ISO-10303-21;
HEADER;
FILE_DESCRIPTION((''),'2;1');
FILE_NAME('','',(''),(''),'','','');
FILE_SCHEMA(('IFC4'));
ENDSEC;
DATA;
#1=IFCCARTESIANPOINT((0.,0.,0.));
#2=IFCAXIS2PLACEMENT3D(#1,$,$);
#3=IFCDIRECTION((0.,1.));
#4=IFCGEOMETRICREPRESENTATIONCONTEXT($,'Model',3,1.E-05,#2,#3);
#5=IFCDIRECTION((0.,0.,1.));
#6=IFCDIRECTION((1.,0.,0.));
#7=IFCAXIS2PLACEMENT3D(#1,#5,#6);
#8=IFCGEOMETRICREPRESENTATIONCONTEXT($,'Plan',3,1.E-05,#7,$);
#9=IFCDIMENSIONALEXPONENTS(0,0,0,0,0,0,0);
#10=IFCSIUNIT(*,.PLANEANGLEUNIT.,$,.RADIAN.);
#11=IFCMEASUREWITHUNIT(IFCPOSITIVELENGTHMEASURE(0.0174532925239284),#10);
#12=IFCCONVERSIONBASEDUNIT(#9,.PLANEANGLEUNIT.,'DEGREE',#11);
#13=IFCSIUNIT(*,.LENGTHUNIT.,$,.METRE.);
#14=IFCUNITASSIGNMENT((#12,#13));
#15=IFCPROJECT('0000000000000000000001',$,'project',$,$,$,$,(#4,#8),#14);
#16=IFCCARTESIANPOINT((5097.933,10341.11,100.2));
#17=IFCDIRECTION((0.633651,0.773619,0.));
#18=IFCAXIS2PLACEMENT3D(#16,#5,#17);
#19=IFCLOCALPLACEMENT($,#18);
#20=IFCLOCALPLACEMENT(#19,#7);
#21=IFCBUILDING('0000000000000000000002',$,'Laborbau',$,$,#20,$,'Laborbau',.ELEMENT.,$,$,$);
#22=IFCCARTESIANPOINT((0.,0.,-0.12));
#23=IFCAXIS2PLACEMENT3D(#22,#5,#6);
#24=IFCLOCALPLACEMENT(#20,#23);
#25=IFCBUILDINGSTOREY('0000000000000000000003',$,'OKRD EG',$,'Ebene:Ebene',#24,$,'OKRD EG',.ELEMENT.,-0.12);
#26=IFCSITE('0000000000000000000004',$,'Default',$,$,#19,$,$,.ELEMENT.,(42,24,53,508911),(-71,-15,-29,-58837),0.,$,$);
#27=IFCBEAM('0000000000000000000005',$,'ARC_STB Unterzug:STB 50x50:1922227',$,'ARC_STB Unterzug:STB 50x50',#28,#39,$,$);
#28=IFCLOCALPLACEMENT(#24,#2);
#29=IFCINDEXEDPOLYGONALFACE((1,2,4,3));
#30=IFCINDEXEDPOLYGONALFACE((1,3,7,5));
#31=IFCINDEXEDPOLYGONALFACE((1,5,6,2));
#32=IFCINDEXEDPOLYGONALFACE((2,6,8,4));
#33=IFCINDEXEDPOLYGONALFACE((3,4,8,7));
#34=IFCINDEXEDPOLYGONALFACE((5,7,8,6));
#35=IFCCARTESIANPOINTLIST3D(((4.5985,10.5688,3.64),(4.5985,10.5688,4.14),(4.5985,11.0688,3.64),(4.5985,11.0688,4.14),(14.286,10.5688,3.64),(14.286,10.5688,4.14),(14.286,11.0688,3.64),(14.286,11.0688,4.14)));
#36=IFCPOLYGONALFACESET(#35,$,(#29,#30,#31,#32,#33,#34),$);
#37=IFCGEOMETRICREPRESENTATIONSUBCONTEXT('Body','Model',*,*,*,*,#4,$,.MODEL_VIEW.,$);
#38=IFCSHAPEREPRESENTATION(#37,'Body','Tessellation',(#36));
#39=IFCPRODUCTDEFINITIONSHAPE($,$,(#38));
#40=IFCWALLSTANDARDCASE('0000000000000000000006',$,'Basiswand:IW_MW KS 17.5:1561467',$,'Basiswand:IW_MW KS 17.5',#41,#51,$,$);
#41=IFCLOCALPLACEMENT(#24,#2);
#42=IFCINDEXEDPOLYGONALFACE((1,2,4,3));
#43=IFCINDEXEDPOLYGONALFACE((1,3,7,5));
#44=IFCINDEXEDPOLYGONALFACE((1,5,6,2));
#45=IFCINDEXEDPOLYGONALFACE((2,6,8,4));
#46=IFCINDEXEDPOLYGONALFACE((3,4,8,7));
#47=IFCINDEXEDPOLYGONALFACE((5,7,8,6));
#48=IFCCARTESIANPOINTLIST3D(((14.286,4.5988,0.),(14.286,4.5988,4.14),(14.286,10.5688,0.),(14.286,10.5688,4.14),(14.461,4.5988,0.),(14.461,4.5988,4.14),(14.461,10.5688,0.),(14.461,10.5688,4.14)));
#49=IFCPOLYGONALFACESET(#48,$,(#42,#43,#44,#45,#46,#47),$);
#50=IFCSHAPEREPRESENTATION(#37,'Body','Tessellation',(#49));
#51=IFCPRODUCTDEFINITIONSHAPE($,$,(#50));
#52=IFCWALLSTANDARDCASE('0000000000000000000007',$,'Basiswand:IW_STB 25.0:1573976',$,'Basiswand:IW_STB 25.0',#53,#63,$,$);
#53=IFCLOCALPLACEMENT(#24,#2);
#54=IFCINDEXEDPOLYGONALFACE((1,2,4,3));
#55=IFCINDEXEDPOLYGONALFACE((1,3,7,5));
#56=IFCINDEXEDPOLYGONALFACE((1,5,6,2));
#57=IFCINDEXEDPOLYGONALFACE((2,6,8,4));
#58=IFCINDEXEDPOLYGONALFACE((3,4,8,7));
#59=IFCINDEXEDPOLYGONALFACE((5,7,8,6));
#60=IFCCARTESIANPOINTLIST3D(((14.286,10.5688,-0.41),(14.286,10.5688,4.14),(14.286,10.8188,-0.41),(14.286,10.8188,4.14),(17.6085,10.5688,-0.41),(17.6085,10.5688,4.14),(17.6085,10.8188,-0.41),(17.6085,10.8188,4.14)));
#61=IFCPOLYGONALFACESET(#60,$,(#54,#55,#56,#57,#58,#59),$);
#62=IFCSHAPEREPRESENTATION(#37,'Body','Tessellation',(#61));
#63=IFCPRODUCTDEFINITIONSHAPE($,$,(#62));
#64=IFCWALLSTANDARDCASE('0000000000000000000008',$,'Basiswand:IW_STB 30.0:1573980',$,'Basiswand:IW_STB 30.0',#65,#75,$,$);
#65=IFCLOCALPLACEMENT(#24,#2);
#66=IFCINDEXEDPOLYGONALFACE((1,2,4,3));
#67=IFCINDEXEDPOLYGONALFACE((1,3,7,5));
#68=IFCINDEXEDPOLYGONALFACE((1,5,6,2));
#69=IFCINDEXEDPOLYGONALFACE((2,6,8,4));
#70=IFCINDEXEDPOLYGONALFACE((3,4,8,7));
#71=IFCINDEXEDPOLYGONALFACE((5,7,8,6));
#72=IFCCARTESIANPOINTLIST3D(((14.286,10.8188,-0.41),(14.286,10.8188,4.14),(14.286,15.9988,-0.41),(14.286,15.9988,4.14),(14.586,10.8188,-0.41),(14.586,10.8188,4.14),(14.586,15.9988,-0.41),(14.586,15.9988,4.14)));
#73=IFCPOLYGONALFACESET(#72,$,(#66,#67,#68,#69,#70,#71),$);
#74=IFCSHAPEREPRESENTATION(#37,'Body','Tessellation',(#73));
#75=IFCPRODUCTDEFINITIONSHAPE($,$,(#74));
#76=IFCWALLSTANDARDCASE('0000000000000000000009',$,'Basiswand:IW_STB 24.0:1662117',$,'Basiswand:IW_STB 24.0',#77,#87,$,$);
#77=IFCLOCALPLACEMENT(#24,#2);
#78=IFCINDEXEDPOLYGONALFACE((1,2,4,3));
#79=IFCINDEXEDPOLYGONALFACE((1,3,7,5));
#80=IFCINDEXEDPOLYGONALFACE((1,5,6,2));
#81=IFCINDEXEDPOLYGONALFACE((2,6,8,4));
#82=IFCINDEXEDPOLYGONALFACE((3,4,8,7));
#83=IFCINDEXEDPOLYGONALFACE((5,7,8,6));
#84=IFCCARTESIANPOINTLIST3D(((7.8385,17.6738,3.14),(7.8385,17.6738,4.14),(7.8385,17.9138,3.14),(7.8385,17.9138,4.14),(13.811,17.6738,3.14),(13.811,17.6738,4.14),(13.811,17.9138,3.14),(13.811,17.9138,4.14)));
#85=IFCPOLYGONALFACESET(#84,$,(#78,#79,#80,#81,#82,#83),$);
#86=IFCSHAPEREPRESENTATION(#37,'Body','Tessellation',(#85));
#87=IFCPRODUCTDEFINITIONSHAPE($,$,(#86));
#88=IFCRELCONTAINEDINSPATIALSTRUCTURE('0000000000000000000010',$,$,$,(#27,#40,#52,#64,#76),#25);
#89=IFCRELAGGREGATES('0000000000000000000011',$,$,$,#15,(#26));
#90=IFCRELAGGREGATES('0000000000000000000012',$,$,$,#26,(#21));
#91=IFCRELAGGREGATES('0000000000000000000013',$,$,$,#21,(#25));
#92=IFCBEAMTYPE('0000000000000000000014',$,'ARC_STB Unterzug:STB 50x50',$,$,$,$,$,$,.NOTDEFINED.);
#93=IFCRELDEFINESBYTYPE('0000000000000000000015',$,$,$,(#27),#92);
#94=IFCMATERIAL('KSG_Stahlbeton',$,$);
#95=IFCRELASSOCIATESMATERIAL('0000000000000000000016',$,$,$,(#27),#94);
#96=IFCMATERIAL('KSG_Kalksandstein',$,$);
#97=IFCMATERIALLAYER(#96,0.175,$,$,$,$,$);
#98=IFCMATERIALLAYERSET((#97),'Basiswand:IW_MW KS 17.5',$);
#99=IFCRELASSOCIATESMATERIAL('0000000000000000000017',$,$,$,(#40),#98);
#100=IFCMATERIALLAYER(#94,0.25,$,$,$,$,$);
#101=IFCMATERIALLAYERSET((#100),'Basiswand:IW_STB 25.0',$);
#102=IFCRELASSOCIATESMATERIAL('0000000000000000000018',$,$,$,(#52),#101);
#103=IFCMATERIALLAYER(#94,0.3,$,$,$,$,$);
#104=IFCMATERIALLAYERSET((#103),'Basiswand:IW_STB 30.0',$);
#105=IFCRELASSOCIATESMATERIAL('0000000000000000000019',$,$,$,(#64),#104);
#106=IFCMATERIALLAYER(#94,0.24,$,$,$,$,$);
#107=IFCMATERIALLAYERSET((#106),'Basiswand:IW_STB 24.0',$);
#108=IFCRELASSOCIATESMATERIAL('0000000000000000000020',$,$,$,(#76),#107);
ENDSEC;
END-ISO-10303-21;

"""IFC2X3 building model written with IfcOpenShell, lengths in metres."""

from ifc_helpers import new_model, entity, si_unit, converted_unit, direction, frame, frame_2d, origin, origin_with_axes, place, context, subcontext, project, spatial, rectangle, extrude, material, layer, layer_set, layer_usage, type_object, element, save


model = new_model("IFC2X3")

# Units and contexts
model_context = context("Model", 3, precision=1e-05, world=origin(), true_north=direction((0.0, 1.0)))
plan_context = context("Plan", 3, precision=1e-05, world=origin_with_axes())
body_context = subcontext(model_context, "Body", "Model", "MODEL_VIEW")
ifc_project = project(units=[converted_unit("PLANEANGLEUNIT", "DEGREE", entity("IfcPositiveLengthMeasure", 0.0174532925239284), si_unit("PLANEANGLEUNIT", "RADIAN"), dimensions=[0, 0, 0, 0, 0, 0, 0]), si_unit("LENGTHUNIT", "METRE")], contexts=[model_context, plan_context])

# Site, building, storey
site_placement = place(None, frame((5097.933, 10341.11, 100.2), z_axis=(0.0, 0.0, 1.0), x_axis=(0.633651, 0.773619, 0.0)))
site = spatial("IfcSite", under=ifc_project, at=site_placement, Name="Default", CompositionType="ELEMENT", RefLatitude=(42, 24, 53, 508911), RefLongitude=(-71, -15, -29, -58837), RefElevation=0.0)
building_placement = place(site_placement, origin_with_axes())
building = spatial("IfcBuilding", under=site, at=building_placement, Name="Laborbau", LongName="Laborbau", CompositionType="ELEMENT")
storey_placement = place(building_placement, frame((0.0, 0.0, -0.12), z_axis=(0.0, 0.0, 1.0), x_axis=(1.0, 0.0, 0.0)))
storey = spatial("IfcBuildingStorey", under=building, at=storey_placement, Name="OKRD EG", ObjectType="Ebene:Ebene", LongName="OKRD EG", CompositionType="ELEMENT", Elevation=-0.12)

# Beam
ifc_material_1 = material(Name="KSG_Stahlbeton")
beam_type = type_object("IfcBeamType", Name="ARC_STB Unterzug:STB 50x50", PredefinedType="NOTDEFINED")
beam_placement = place(storey_placement, frame((14.436, 10.8188, 4.14), z_axis=(0.0, 0.0, 1.0), x_axis=(-1.0, 0.0, 0.0)))
element("IfcBeam", 1, at=beam_placement, inside=storey, type_object=beam_type, material=ifc_material_1, Name="ARC_STB Unterzug:STB 50x50:1922227", ObjectType="ARC_STB Unterzug:STB 50x50", context=body_context, shape_type="SweptSolid", body=[
    extrude(rectangle(XDim=0.5, YDim=0.5, at=frame_2d((0.0, 0.0), x_axis=(1.0, 0.0))), frame((0.15, 0.0, -0.25), z_axis=(1.0, 0.0, 0.0), x_axis=(0.0, 0.0, -1.0)), (0.0, 0.0, 1.0), 9.6875),
])

# Walls
ifc_material_2 = material(Name="KSG_Kalksandstein")
ifc_layer_1 = layer(ifc_material_2, 0.175)
ifc_layer_set_1 = layer_set([ifc_layer_1], Name="Basiswand:IW_MW KS 17.5")
ifc_layer_usage_1 = layer_usage(ifc_layer_set_1, "AXIS2", "NEGATIVE", 0.0875)
wall_1_placement = place(storey_placement, frame((14.3735, 10.5688, 0.0), z_axis=(0.0, 0.0, 1.0), x_axis=(0.0, -1.0, 0.0)))
element("IfcWallStandardCase", 2, at=wall_1_placement, inside=storey, material=ifc_layer_usage_1, Name="Basiswand:IW_MW KS 17.5:1561467", ObjectType="Basiswand:IW_MW KS 17.5", context=body_context, shape_type="SweptSolid", body=[
    extrude(rectangle(XDim=5.97, YDim=0.175, at=frame_2d((2.985, 0.0), x_axis=(-1.0, 0.0))), origin(), (0.0, 0.0, 1.0), 4.14),
])
ifc_layer_2 = layer(ifc_material_1, 0.25)
ifc_layer_set_2 = layer_set([ifc_layer_2], Name="Basiswand:IW_STB 25.0")
ifc_layer_usage_2 = layer_usage(ifc_layer_set_2, "AXIS2", "NEGATIVE", 0.125)
wall_2_placement = place(storey_placement, frame((14.286, 10.6938, -0.41), z_axis=(0.0, 0.0, 1.0), x_axis=(1.0, 0.0, 0.0)))
element("IfcWallStandardCase", 3, at=wall_2_placement, inside=storey, material=ifc_layer_usage_2, Name="Basiswand:IW_STB 25.0:1573976", ObjectType="Basiswand:IW_STB 25.0", context=body_context, shape_type="SweptSolid", body=[
    extrude(rectangle(XDim=3.3225, YDim=0.25, at=frame_2d((1.6613, 0.0), x_axis=(-1.0, 0.0))), origin(), (0.0, 0.0, 1.0), 4.55),
])
ifc_layer_3 = layer(ifc_material_1, 0.3)
ifc_layer_set_3 = layer_set([ifc_layer_3], Name="Basiswand:IW_STB 30.0")
ifc_layer_usage_3 = layer_usage(ifc_layer_set_3, "AXIS2", "POSITIVE", -0.15)
wall_3_placement = place(storey_placement, frame((14.436, 10.8188, -0.41), z_axis=(0.0, 0.0, 1.0), x_axis=(0.0, 1.0, 0.0)))
element("IfcWallStandardCase", 4, at=wall_3_placement, inside=storey, material=ifc_layer_usage_3, Name="Basiswand:IW_STB 30.0:1573980", ObjectType="Basiswand:IW_STB 30.0", context=body_context, shape_type="SweptSolid", body=[
    extrude(rectangle(XDim=5.18, YDim=0.3, at=frame_2d((2.59, 0.0), x_axis=(-1.0, 0.0))), origin(), (0.0, 0.0, 1.0), 4.55),
])
ifc_layer_4 = layer(ifc_material_1, 0.24)
ifc_layer_set_4 = layer_set([ifc_layer_4], Name="Basiswand:IW_STB 24.0")
ifc_layer_usage_4 = layer_usage(ifc_layer_set_4, "AXIS2", "POSITIVE", -0.12)
wall_4_placement = place(storey_placement, frame((7.8385, 17.7938, 3.14), z_axis=(0.0, 0.0, 1.0), x_axis=(1.0, 0.0, 0.0)))
element("IfcWallStandardCase", 5, at=wall_4_placement, inside=storey, material=ifc_layer_usage_4, Name="Basiswand:IW_STB 24.0:1662117", ObjectType="Basiswand:IW_STB 24.0", context=body_context, shape_type="SweptSolid", body=[
    extrude(rectangle(XDim=5.9725, YDim=0.24, at=frame_2d((2.9863, 0.0), x_axis=(-1.0, 0.0))), origin(), (0.0, 0.0, 1.0), 1.0),
])

save(model, "model.ifc")
